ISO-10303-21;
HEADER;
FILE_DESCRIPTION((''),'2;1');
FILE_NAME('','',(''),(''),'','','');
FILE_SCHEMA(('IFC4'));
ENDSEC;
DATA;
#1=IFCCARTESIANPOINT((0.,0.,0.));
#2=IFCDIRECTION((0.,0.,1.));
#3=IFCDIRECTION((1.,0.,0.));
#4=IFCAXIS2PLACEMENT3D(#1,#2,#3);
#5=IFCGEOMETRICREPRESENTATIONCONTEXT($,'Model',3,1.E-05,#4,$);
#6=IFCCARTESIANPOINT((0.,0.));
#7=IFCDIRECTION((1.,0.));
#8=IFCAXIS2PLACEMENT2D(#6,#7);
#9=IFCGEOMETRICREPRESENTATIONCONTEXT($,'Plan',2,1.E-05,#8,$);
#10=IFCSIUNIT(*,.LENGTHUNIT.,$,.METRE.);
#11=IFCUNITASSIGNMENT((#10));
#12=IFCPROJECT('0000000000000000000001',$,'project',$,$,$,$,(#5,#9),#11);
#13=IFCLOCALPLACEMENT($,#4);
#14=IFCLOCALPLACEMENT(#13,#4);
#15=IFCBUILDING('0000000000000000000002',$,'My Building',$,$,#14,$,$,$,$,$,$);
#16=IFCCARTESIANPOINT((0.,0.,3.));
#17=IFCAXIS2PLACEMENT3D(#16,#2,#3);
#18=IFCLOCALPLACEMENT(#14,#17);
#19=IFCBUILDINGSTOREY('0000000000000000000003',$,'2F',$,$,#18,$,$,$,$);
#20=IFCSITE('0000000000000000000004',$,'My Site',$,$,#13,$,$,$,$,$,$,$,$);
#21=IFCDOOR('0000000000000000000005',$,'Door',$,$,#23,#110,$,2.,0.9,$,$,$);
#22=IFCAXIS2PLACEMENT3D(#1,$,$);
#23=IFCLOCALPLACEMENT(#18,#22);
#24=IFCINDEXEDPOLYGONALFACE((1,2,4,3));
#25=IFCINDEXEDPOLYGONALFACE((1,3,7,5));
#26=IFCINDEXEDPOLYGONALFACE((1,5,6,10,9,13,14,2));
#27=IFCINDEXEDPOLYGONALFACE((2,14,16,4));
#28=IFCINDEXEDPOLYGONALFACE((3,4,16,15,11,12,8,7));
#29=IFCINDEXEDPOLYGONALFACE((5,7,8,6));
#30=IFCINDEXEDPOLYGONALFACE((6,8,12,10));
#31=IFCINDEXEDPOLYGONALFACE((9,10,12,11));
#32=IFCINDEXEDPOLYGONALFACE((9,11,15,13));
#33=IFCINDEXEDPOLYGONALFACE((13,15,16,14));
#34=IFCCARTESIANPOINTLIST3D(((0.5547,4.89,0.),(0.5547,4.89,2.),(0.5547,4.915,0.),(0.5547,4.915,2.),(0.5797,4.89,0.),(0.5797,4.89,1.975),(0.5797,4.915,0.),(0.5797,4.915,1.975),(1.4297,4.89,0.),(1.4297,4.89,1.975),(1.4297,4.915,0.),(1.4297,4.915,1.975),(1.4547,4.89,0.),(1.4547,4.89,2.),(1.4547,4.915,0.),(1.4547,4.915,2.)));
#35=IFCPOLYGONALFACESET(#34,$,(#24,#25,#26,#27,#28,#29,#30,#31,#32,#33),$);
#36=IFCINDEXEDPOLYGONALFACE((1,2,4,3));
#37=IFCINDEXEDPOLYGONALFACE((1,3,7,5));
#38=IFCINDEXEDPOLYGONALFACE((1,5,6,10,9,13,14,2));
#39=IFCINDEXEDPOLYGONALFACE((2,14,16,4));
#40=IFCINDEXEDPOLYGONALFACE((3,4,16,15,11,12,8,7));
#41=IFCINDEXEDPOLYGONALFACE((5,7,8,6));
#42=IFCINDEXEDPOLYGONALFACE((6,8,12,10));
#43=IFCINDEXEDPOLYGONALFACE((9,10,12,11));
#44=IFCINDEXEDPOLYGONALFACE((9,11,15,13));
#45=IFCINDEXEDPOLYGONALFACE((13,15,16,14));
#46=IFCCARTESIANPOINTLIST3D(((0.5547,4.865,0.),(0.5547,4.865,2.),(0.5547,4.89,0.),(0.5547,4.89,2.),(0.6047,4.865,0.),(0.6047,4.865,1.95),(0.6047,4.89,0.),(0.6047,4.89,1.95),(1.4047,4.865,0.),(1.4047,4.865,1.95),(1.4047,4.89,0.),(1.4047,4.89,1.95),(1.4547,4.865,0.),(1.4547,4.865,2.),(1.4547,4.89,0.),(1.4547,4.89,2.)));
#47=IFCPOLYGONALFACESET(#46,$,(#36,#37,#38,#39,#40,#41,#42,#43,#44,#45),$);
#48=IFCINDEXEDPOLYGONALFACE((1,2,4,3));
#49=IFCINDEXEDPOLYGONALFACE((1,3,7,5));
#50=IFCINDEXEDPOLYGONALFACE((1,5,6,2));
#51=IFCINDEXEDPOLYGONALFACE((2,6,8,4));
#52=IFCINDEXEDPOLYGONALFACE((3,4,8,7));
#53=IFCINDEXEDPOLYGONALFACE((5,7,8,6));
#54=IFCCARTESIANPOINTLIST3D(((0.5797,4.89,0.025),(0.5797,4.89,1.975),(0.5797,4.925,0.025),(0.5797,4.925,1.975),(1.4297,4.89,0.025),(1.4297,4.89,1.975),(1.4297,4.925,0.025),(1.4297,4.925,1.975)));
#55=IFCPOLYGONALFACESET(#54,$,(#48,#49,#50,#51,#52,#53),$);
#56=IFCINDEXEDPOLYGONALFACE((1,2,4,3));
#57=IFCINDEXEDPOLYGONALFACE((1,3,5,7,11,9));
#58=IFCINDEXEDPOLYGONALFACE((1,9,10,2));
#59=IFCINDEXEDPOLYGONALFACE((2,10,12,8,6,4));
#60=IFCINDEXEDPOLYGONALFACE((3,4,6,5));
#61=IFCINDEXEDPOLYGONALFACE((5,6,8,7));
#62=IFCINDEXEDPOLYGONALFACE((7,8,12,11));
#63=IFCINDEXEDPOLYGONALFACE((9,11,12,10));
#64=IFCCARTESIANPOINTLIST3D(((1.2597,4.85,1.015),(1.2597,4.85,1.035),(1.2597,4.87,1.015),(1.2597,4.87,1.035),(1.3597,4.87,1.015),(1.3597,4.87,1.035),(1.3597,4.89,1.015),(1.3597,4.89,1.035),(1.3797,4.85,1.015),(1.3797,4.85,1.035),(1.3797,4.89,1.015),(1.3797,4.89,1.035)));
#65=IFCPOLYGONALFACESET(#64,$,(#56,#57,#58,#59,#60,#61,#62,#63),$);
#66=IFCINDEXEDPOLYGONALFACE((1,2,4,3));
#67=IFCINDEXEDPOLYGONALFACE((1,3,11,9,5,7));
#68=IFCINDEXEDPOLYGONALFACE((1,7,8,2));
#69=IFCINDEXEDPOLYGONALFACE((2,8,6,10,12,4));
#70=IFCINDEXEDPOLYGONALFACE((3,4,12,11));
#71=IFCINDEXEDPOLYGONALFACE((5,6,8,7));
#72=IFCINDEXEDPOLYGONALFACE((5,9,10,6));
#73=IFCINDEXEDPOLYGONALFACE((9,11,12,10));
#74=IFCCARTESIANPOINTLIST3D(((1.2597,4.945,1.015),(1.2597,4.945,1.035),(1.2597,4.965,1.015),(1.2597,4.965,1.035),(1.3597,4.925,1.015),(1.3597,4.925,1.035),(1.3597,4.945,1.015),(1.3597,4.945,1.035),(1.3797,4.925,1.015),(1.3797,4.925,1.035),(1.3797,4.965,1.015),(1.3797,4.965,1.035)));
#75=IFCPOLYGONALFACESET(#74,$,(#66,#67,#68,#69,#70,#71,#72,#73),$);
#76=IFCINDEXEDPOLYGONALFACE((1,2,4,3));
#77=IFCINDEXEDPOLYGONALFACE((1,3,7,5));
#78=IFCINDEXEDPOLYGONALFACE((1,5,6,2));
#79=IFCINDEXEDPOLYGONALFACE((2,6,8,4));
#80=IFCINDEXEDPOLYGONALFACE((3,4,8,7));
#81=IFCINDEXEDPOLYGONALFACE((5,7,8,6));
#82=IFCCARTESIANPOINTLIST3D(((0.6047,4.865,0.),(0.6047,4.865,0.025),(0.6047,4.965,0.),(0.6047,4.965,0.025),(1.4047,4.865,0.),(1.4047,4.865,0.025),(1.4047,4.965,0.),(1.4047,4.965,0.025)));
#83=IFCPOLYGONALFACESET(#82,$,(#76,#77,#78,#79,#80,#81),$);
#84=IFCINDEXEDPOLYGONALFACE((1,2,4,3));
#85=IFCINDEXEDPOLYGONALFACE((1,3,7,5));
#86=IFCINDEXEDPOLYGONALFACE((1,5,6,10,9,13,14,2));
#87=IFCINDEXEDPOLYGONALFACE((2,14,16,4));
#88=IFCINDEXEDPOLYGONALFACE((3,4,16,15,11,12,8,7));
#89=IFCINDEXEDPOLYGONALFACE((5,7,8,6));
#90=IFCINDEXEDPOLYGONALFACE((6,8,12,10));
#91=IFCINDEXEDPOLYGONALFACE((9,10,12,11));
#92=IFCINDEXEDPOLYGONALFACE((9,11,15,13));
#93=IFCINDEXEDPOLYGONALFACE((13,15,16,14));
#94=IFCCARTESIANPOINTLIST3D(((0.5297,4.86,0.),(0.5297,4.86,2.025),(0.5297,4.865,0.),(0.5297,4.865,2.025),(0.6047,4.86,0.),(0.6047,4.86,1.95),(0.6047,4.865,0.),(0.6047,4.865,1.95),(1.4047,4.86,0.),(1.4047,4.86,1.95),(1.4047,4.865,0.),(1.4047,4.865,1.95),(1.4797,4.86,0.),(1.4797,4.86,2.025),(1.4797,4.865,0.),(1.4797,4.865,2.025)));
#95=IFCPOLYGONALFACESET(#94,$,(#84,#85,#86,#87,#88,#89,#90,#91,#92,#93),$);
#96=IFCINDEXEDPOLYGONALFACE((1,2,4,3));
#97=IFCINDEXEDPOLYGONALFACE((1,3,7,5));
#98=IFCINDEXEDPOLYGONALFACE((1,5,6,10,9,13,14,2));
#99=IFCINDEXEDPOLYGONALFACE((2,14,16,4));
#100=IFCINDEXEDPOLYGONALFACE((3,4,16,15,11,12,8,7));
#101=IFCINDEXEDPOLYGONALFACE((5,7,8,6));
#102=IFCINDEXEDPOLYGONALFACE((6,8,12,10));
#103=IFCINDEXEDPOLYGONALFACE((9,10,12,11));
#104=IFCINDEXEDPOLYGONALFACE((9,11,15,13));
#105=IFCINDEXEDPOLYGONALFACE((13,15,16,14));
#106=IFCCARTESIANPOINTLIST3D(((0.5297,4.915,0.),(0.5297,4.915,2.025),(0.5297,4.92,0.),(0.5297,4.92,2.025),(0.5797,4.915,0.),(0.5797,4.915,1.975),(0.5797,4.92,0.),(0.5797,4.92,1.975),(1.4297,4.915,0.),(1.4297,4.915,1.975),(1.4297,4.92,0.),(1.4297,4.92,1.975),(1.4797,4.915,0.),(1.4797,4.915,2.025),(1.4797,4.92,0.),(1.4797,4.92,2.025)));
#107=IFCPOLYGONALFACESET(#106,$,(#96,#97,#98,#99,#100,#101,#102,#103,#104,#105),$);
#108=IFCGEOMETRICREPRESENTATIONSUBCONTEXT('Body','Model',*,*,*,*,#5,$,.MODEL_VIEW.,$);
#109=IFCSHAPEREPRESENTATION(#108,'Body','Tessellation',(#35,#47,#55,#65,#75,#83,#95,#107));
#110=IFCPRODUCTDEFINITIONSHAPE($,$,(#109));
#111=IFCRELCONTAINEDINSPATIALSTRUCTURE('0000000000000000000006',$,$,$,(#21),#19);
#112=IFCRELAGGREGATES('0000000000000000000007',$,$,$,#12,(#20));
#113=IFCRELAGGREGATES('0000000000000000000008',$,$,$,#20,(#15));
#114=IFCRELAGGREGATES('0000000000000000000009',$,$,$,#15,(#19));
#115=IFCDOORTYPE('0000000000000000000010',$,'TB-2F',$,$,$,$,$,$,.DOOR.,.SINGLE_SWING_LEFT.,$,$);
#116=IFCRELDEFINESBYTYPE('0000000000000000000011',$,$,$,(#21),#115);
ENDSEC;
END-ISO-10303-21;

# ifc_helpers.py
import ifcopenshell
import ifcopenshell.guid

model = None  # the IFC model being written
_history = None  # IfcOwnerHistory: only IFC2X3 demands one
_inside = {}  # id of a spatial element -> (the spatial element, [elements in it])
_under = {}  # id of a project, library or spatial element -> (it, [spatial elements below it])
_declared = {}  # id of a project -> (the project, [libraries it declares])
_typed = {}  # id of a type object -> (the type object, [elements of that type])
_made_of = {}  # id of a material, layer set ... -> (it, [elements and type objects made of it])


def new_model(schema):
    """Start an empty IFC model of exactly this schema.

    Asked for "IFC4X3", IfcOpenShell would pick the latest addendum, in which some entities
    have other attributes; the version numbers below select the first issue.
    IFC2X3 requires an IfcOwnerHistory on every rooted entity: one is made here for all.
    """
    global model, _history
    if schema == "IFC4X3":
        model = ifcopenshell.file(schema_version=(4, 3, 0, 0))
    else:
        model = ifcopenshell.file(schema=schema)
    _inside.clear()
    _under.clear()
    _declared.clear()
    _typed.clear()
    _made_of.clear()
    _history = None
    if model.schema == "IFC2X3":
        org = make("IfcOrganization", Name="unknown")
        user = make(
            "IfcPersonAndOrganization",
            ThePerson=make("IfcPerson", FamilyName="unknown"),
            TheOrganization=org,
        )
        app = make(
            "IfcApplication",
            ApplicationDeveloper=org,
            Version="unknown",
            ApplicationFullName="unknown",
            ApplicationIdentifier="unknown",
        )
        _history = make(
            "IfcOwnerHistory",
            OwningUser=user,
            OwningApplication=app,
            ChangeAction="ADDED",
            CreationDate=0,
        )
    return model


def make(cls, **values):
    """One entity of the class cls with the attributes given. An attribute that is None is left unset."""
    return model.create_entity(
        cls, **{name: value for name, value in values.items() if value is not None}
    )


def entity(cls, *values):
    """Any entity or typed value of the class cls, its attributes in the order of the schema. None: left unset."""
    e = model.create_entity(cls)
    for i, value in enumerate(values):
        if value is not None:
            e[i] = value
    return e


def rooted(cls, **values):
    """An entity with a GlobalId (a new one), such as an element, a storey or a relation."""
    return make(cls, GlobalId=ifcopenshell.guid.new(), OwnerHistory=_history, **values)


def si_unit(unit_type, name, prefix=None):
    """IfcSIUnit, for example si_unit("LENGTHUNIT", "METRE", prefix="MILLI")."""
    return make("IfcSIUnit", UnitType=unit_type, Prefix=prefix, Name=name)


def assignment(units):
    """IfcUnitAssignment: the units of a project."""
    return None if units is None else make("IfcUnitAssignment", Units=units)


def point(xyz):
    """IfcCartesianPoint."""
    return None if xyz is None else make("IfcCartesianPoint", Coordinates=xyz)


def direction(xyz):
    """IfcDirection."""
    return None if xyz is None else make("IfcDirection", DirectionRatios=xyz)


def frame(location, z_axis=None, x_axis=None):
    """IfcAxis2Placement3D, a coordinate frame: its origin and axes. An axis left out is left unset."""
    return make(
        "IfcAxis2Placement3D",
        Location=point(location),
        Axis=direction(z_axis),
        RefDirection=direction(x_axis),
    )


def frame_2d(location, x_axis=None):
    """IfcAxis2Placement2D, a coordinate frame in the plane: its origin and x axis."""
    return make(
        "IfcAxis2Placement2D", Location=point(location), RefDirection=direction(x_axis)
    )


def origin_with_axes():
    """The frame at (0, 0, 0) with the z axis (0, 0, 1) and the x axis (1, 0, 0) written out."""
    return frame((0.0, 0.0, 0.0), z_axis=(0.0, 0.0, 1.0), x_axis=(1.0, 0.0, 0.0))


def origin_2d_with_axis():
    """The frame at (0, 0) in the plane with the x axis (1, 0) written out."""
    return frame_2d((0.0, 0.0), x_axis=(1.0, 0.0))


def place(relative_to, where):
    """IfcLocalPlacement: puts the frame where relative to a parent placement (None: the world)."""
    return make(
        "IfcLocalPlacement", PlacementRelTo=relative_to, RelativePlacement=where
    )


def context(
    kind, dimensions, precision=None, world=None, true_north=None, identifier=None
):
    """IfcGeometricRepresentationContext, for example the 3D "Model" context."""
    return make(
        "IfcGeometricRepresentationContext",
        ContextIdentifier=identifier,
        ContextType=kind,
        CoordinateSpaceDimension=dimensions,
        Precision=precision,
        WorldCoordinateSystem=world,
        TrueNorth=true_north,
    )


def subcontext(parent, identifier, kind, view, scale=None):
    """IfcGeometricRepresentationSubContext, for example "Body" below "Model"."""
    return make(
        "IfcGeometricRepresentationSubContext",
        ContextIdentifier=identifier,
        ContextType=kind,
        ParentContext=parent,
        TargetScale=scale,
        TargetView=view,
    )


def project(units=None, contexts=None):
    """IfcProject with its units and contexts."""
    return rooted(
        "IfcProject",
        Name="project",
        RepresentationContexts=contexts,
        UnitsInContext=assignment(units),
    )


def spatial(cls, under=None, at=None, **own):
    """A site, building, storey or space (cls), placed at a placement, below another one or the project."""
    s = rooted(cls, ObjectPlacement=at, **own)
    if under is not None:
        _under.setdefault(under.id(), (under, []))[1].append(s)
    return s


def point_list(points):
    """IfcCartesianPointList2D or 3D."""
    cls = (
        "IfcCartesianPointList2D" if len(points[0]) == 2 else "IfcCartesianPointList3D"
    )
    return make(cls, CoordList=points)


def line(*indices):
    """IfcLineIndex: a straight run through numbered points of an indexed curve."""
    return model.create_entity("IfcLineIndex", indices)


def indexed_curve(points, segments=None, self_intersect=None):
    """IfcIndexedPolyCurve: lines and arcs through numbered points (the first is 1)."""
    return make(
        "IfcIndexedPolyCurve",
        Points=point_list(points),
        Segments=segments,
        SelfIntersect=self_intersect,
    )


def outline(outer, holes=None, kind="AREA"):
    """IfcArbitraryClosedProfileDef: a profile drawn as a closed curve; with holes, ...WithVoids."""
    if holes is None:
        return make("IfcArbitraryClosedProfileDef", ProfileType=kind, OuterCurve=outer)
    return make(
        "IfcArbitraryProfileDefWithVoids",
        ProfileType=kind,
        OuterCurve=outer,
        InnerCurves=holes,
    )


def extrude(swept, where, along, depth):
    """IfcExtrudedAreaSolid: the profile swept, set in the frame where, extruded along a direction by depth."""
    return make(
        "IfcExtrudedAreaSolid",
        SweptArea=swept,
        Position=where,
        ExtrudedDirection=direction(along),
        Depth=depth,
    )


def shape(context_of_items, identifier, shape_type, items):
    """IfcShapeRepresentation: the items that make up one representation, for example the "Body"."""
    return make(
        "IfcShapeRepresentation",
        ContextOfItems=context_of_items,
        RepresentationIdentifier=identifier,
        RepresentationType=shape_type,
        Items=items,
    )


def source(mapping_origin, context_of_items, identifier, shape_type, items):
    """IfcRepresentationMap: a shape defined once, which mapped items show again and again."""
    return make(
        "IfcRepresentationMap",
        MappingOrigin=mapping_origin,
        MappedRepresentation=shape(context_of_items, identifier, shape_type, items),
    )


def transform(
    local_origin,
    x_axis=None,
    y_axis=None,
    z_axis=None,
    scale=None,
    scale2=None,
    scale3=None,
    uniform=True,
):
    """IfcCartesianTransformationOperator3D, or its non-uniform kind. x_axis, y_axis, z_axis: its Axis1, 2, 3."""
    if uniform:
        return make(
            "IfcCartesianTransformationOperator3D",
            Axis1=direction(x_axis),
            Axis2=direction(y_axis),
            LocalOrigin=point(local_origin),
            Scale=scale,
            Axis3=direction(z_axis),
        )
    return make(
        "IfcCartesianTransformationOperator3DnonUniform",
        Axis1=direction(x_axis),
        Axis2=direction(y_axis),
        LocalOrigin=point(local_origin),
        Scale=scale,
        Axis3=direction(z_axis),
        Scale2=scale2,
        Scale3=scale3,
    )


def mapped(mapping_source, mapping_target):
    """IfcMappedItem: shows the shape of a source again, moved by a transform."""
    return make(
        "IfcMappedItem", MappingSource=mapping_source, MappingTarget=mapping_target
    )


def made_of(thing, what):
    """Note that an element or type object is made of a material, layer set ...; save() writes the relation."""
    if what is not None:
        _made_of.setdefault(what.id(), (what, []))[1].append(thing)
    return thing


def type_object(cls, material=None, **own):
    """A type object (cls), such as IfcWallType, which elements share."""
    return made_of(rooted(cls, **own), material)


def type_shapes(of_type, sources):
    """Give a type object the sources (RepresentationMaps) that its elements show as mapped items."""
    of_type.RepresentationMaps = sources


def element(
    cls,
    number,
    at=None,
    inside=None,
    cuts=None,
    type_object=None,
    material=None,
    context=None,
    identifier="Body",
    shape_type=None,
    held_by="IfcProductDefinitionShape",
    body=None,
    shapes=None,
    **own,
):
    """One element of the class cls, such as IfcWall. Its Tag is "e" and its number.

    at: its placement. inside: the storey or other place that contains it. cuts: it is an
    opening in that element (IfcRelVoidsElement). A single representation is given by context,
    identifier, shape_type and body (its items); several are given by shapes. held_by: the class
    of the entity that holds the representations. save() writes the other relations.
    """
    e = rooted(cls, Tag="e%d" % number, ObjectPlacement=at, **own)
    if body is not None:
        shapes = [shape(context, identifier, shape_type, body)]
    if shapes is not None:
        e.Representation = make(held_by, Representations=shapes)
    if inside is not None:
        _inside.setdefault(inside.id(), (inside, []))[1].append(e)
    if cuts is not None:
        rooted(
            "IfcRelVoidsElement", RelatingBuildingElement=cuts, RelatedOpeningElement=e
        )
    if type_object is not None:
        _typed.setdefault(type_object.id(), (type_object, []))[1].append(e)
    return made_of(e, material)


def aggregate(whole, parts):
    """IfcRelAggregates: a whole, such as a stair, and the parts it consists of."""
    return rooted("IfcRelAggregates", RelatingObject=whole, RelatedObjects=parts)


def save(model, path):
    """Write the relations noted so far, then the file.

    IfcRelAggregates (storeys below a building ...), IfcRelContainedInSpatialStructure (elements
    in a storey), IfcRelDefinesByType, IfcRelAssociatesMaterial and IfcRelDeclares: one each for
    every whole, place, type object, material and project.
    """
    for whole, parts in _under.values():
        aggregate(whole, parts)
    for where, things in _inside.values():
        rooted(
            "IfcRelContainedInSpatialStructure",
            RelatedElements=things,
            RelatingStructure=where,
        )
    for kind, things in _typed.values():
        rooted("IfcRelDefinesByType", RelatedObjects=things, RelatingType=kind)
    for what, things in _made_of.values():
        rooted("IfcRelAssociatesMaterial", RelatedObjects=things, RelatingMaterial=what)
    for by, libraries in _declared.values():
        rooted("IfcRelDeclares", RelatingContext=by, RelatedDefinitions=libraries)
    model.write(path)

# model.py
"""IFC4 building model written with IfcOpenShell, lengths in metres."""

from ifc_helpers import new_model, entity, si_unit, frame, origin_with_axes, origin_2d_with_axis, place, context, subcontext, project, spatial, line, indexed_curve, outline, extrude, shape, source, transform, mapped, type_object, type_shapes, element, save


model = new_model("IFC4")

# Units and contexts
model_context = context("Model", 3, precision=1e-05, world=origin_with_axes())
plan_context = context("Plan", 2, precision=1e-05, world=origin_2d_with_axis())
body_context_1 = subcontext(model_context, "Body", "Model", "MODEL_VIEW")
body_context_2 = subcontext(plan_context, "Body", "Plan", "PLAN_VIEW")
ifc_project = project(units=[si_unit("LENGTHUNIT", "METRE")], contexts=[model_context, plan_context])

# Site, building, storey
site_placement = place(None, origin_with_axes())
site = spatial("IfcSite", under=ifc_project, at=site_placement, Name="My Site")
building_placement = place(site_placement, origin_with_axes())
building = spatial("IfcBuilding", under=site, at=building_placement, Name="My Building")
storey_placement = place(building_placement, frame((0.0, 0.0, 3.0), z_axis=(0.0, 0.0, 1.0), x_axis=(1.0, 0.0, 0.0)))
storey = spatial("IfcBuildingStorey", under=building, at=storey_placement, Name="2F")

# Door
door_type_1 = type_object("IfcDoorType", Name="TB-2F", OperationType="SINGLE_SWING_LEFT", PredefinedType="DOOR")
shared_shape_1 = source(origin_with_axes(), body_context_1, "Body", "SweptSolid", [
    extrude(outline(indexed_curve([(0.0, 0.0), (0.0, 2.0), (0.9, 2.0), (0.9, 0.0), (0.875, 0.0), (0.875, 1.975), (0.025, 1.975), (0.025, 0.0)], segments=[line(1, 2, 3, 4, 5, 6, 7, 8, 1)])), frame((0.0, 0.025, 0.0), z_axis=(0.0, -1.0, 0.0), x_axis=(1.0, 0.0, 0.0)), (0.0, 0.0, -1.0), 0.025),
    extrude(outline(indexed_curve([(0.0, 0.0), (0.0, 2.0), (0.9, 2.0), (0.9, 0.0), (0.85, 0.0), (0.85, 1.95), (0.05, 1.95), (0.05, 0.0)], segments=[line(1, 2, 3, 4, 5, 6, 7, 8, 1)])), frame((0.0, 0.0, 0.0), z_axis=(0.0, -1.0, 0.0), x_axis=(1.0, 0.0, 0.0)), (0.0, 0.0, -1.0), 0.025),
    extrude(outline(indexed_curve([(0.0, 0.0), (0.85, 0.0), (0.85, 0.035), (0.0, 0.035)], segments=[line(1, 2, 3, 4, 1)])), frame((0.025, 0.025, 0.025), z_axis=(0.0, 0.0, 1.0), x_axis=(1.0, 0.0, 0.0)), (0.0, 0.0, 1.0), 1.95),
    extrude(outline(indexed_curve([(0.0, 0.0), (0.0, -0.04), (-0.12, -0.04), (-0.12, -0.02), (-0.02, -0.02), (-0.02, 0.0)], segments=[line(1, 2, 3, 4, 5, 6, 1)])), frame((0.825, 0.025, 1.015), z_axis=(0.0, 0.0, 1.0), x_axis=(1.0, 0.0, 0.0)), (0.0, 0.0, 1.0), 0.02),
    extrude(outline(indexed_curve([(0.0, 0.0), (0.0, 0.04), (-0.12, 0.04), (-0.12, 0.02), (-0.02, 0.02), (-0.02, 0.0)], segments=[line(1, 2, 3, 4, 5, 6, 1)])), frame((0.825, 0.06, 1.015), z_axis=(0.0, 0.0, 1.0), x_axis=(1.0, 0.0, 0.0)), (0.0, 0.0, 1.0), 0.02),
    extrude(outline(indexed_curve([(0.0, 0.0), (0.8, 0.0), (0.8, 0.1), (0.0, 0.1)], segments=[line(1, 2, 3, 4, 1)])), frame((0.05, 0.0, 0.0), z_axis=(0.0, 0.0, 1.0), x_axis=(1.0, 0.0, 0.0)), (0.0, 0.0, 1.0), 0.025),
    extrude(outline(indexed_curve([(0.0, 0.0), (0.0, 2.025), (0.95, 2.025), (0.95, 0.0), (0.875, 0.0), (0.875, 1.95), (0.075, 1.95), (0.075, 0.0)], segments=[line(1, 2, 3, 4, 5, 6, 7, 8, 1)])), frame((-0.025, -0.005, 0.0), z_axis=(0.0, -1.0, 0.0), x_axis=(1.0, 0.0, 0.0)), (0.0, 0.0, -1.0), 0.005),
    extrude(outline(indexed_curve([(0.0, 0.0), (0.0, 2.025), (0.95, 2.025), (0.95, 0.0), (0.9, 0.0), (0.9, 1.975), (0.05, 1.975), (0.05, 0.0)], segments=[line(1, 2, 3, 4, 5, 6, 7, 8, 1)])), frame((-0.025, 0.05, 0.0), z_axis=(0.0, -1.0, 0.0), x_axis=(1.0, 0.0, 0.0)), (0.0, 0.0, -1.0), 0.005),
])
shared_shape_2 = source(origin_with_axes(), body_context_2, "Body", "Curve2D", [
    entity("IfcIndexedPolyCurve", entity("IfcCartesianPointList2D", [[0.0, 0.0], [0.0, 0.05], [0.025, 0.05], [0.025, 0.025], [0.05, 0.025], [0.05, 0.0]]), [entity("IfcLineIndex", [1, 2, 3, 4, 5, 6, 1])]),
    entity("IfcIndexedPolyCurve", entity("IfcCartesianPointList2D", [[0.9, 0.0], [0.9, 0.05], [0.875, 0.05], [0.875, 0.025], [0.85, 0.025], [0.85, 0.0]]), [entity("IfcLineIndex", [1, 2, 3, 4, 5, 6, 1])]),
    entity("IfcTrimmedCurve", entity("IfcEllipse", entity("IfcAxis2Placement2D", entity("IfcCartesianPoint", [0.06, 0.05]), entity("IfcDirection", [1.0, 0.0])), 0.815, 0.85), [entity("IfcCartesianPoint", [0.875, 0.05])], [entity("IfcCartesianPoint", [0.06, 0.9])], True, "CARTESIAN"),
    entity("IfcIndexedPolyCurve", entity("IfcCartesianPointList2D", [[0.025, 0.05], [0.06, 0.05], [0.06, 0.9], [0.025, 0.9]]), [entity("IfcLineIndex", [1, 2, 3, 4, 1])]),
])
type_shapes(door_type_1, [shared_shape_1, shared_shape_2])
door_1_placement = place(storey_placement, frame((0.5547, 4.865, 0.0), z_axis=(0.0, 0.0, 1.0), x_axis=(1.0, 0.0, 0.0)))
element("IfcDoor", 1, at=door_1_placement, inside=storey, type_object=door_type_1, Name="Door", OverallHeight=2.0, OverallWidth=0.9, shapes=[
    shape(body_context_1, "Body", "MappedRepresentation", [mapped(shared_shape_1, transform((0.0, 0.0, 0.0), x_axis=(1.0, 0.0, 0.0), y_axis=(0.0, 1.0, 0.0), z_axis=(0.0, 0.0, 1.0), scale=1.0))]),
    shape(body_context_2, "Body", "MappedRepresentation", [mapped(shared_shape_2, transform((0.0, 0.0, 0.0), x_axis=(1.0, 0.0, 0.0), y_axis=(0.0, 1.0, 0.0), z_axis=(0.0, 0.0, 1.0), scale=1.0))]),
])

save(model, "model.ifc")
